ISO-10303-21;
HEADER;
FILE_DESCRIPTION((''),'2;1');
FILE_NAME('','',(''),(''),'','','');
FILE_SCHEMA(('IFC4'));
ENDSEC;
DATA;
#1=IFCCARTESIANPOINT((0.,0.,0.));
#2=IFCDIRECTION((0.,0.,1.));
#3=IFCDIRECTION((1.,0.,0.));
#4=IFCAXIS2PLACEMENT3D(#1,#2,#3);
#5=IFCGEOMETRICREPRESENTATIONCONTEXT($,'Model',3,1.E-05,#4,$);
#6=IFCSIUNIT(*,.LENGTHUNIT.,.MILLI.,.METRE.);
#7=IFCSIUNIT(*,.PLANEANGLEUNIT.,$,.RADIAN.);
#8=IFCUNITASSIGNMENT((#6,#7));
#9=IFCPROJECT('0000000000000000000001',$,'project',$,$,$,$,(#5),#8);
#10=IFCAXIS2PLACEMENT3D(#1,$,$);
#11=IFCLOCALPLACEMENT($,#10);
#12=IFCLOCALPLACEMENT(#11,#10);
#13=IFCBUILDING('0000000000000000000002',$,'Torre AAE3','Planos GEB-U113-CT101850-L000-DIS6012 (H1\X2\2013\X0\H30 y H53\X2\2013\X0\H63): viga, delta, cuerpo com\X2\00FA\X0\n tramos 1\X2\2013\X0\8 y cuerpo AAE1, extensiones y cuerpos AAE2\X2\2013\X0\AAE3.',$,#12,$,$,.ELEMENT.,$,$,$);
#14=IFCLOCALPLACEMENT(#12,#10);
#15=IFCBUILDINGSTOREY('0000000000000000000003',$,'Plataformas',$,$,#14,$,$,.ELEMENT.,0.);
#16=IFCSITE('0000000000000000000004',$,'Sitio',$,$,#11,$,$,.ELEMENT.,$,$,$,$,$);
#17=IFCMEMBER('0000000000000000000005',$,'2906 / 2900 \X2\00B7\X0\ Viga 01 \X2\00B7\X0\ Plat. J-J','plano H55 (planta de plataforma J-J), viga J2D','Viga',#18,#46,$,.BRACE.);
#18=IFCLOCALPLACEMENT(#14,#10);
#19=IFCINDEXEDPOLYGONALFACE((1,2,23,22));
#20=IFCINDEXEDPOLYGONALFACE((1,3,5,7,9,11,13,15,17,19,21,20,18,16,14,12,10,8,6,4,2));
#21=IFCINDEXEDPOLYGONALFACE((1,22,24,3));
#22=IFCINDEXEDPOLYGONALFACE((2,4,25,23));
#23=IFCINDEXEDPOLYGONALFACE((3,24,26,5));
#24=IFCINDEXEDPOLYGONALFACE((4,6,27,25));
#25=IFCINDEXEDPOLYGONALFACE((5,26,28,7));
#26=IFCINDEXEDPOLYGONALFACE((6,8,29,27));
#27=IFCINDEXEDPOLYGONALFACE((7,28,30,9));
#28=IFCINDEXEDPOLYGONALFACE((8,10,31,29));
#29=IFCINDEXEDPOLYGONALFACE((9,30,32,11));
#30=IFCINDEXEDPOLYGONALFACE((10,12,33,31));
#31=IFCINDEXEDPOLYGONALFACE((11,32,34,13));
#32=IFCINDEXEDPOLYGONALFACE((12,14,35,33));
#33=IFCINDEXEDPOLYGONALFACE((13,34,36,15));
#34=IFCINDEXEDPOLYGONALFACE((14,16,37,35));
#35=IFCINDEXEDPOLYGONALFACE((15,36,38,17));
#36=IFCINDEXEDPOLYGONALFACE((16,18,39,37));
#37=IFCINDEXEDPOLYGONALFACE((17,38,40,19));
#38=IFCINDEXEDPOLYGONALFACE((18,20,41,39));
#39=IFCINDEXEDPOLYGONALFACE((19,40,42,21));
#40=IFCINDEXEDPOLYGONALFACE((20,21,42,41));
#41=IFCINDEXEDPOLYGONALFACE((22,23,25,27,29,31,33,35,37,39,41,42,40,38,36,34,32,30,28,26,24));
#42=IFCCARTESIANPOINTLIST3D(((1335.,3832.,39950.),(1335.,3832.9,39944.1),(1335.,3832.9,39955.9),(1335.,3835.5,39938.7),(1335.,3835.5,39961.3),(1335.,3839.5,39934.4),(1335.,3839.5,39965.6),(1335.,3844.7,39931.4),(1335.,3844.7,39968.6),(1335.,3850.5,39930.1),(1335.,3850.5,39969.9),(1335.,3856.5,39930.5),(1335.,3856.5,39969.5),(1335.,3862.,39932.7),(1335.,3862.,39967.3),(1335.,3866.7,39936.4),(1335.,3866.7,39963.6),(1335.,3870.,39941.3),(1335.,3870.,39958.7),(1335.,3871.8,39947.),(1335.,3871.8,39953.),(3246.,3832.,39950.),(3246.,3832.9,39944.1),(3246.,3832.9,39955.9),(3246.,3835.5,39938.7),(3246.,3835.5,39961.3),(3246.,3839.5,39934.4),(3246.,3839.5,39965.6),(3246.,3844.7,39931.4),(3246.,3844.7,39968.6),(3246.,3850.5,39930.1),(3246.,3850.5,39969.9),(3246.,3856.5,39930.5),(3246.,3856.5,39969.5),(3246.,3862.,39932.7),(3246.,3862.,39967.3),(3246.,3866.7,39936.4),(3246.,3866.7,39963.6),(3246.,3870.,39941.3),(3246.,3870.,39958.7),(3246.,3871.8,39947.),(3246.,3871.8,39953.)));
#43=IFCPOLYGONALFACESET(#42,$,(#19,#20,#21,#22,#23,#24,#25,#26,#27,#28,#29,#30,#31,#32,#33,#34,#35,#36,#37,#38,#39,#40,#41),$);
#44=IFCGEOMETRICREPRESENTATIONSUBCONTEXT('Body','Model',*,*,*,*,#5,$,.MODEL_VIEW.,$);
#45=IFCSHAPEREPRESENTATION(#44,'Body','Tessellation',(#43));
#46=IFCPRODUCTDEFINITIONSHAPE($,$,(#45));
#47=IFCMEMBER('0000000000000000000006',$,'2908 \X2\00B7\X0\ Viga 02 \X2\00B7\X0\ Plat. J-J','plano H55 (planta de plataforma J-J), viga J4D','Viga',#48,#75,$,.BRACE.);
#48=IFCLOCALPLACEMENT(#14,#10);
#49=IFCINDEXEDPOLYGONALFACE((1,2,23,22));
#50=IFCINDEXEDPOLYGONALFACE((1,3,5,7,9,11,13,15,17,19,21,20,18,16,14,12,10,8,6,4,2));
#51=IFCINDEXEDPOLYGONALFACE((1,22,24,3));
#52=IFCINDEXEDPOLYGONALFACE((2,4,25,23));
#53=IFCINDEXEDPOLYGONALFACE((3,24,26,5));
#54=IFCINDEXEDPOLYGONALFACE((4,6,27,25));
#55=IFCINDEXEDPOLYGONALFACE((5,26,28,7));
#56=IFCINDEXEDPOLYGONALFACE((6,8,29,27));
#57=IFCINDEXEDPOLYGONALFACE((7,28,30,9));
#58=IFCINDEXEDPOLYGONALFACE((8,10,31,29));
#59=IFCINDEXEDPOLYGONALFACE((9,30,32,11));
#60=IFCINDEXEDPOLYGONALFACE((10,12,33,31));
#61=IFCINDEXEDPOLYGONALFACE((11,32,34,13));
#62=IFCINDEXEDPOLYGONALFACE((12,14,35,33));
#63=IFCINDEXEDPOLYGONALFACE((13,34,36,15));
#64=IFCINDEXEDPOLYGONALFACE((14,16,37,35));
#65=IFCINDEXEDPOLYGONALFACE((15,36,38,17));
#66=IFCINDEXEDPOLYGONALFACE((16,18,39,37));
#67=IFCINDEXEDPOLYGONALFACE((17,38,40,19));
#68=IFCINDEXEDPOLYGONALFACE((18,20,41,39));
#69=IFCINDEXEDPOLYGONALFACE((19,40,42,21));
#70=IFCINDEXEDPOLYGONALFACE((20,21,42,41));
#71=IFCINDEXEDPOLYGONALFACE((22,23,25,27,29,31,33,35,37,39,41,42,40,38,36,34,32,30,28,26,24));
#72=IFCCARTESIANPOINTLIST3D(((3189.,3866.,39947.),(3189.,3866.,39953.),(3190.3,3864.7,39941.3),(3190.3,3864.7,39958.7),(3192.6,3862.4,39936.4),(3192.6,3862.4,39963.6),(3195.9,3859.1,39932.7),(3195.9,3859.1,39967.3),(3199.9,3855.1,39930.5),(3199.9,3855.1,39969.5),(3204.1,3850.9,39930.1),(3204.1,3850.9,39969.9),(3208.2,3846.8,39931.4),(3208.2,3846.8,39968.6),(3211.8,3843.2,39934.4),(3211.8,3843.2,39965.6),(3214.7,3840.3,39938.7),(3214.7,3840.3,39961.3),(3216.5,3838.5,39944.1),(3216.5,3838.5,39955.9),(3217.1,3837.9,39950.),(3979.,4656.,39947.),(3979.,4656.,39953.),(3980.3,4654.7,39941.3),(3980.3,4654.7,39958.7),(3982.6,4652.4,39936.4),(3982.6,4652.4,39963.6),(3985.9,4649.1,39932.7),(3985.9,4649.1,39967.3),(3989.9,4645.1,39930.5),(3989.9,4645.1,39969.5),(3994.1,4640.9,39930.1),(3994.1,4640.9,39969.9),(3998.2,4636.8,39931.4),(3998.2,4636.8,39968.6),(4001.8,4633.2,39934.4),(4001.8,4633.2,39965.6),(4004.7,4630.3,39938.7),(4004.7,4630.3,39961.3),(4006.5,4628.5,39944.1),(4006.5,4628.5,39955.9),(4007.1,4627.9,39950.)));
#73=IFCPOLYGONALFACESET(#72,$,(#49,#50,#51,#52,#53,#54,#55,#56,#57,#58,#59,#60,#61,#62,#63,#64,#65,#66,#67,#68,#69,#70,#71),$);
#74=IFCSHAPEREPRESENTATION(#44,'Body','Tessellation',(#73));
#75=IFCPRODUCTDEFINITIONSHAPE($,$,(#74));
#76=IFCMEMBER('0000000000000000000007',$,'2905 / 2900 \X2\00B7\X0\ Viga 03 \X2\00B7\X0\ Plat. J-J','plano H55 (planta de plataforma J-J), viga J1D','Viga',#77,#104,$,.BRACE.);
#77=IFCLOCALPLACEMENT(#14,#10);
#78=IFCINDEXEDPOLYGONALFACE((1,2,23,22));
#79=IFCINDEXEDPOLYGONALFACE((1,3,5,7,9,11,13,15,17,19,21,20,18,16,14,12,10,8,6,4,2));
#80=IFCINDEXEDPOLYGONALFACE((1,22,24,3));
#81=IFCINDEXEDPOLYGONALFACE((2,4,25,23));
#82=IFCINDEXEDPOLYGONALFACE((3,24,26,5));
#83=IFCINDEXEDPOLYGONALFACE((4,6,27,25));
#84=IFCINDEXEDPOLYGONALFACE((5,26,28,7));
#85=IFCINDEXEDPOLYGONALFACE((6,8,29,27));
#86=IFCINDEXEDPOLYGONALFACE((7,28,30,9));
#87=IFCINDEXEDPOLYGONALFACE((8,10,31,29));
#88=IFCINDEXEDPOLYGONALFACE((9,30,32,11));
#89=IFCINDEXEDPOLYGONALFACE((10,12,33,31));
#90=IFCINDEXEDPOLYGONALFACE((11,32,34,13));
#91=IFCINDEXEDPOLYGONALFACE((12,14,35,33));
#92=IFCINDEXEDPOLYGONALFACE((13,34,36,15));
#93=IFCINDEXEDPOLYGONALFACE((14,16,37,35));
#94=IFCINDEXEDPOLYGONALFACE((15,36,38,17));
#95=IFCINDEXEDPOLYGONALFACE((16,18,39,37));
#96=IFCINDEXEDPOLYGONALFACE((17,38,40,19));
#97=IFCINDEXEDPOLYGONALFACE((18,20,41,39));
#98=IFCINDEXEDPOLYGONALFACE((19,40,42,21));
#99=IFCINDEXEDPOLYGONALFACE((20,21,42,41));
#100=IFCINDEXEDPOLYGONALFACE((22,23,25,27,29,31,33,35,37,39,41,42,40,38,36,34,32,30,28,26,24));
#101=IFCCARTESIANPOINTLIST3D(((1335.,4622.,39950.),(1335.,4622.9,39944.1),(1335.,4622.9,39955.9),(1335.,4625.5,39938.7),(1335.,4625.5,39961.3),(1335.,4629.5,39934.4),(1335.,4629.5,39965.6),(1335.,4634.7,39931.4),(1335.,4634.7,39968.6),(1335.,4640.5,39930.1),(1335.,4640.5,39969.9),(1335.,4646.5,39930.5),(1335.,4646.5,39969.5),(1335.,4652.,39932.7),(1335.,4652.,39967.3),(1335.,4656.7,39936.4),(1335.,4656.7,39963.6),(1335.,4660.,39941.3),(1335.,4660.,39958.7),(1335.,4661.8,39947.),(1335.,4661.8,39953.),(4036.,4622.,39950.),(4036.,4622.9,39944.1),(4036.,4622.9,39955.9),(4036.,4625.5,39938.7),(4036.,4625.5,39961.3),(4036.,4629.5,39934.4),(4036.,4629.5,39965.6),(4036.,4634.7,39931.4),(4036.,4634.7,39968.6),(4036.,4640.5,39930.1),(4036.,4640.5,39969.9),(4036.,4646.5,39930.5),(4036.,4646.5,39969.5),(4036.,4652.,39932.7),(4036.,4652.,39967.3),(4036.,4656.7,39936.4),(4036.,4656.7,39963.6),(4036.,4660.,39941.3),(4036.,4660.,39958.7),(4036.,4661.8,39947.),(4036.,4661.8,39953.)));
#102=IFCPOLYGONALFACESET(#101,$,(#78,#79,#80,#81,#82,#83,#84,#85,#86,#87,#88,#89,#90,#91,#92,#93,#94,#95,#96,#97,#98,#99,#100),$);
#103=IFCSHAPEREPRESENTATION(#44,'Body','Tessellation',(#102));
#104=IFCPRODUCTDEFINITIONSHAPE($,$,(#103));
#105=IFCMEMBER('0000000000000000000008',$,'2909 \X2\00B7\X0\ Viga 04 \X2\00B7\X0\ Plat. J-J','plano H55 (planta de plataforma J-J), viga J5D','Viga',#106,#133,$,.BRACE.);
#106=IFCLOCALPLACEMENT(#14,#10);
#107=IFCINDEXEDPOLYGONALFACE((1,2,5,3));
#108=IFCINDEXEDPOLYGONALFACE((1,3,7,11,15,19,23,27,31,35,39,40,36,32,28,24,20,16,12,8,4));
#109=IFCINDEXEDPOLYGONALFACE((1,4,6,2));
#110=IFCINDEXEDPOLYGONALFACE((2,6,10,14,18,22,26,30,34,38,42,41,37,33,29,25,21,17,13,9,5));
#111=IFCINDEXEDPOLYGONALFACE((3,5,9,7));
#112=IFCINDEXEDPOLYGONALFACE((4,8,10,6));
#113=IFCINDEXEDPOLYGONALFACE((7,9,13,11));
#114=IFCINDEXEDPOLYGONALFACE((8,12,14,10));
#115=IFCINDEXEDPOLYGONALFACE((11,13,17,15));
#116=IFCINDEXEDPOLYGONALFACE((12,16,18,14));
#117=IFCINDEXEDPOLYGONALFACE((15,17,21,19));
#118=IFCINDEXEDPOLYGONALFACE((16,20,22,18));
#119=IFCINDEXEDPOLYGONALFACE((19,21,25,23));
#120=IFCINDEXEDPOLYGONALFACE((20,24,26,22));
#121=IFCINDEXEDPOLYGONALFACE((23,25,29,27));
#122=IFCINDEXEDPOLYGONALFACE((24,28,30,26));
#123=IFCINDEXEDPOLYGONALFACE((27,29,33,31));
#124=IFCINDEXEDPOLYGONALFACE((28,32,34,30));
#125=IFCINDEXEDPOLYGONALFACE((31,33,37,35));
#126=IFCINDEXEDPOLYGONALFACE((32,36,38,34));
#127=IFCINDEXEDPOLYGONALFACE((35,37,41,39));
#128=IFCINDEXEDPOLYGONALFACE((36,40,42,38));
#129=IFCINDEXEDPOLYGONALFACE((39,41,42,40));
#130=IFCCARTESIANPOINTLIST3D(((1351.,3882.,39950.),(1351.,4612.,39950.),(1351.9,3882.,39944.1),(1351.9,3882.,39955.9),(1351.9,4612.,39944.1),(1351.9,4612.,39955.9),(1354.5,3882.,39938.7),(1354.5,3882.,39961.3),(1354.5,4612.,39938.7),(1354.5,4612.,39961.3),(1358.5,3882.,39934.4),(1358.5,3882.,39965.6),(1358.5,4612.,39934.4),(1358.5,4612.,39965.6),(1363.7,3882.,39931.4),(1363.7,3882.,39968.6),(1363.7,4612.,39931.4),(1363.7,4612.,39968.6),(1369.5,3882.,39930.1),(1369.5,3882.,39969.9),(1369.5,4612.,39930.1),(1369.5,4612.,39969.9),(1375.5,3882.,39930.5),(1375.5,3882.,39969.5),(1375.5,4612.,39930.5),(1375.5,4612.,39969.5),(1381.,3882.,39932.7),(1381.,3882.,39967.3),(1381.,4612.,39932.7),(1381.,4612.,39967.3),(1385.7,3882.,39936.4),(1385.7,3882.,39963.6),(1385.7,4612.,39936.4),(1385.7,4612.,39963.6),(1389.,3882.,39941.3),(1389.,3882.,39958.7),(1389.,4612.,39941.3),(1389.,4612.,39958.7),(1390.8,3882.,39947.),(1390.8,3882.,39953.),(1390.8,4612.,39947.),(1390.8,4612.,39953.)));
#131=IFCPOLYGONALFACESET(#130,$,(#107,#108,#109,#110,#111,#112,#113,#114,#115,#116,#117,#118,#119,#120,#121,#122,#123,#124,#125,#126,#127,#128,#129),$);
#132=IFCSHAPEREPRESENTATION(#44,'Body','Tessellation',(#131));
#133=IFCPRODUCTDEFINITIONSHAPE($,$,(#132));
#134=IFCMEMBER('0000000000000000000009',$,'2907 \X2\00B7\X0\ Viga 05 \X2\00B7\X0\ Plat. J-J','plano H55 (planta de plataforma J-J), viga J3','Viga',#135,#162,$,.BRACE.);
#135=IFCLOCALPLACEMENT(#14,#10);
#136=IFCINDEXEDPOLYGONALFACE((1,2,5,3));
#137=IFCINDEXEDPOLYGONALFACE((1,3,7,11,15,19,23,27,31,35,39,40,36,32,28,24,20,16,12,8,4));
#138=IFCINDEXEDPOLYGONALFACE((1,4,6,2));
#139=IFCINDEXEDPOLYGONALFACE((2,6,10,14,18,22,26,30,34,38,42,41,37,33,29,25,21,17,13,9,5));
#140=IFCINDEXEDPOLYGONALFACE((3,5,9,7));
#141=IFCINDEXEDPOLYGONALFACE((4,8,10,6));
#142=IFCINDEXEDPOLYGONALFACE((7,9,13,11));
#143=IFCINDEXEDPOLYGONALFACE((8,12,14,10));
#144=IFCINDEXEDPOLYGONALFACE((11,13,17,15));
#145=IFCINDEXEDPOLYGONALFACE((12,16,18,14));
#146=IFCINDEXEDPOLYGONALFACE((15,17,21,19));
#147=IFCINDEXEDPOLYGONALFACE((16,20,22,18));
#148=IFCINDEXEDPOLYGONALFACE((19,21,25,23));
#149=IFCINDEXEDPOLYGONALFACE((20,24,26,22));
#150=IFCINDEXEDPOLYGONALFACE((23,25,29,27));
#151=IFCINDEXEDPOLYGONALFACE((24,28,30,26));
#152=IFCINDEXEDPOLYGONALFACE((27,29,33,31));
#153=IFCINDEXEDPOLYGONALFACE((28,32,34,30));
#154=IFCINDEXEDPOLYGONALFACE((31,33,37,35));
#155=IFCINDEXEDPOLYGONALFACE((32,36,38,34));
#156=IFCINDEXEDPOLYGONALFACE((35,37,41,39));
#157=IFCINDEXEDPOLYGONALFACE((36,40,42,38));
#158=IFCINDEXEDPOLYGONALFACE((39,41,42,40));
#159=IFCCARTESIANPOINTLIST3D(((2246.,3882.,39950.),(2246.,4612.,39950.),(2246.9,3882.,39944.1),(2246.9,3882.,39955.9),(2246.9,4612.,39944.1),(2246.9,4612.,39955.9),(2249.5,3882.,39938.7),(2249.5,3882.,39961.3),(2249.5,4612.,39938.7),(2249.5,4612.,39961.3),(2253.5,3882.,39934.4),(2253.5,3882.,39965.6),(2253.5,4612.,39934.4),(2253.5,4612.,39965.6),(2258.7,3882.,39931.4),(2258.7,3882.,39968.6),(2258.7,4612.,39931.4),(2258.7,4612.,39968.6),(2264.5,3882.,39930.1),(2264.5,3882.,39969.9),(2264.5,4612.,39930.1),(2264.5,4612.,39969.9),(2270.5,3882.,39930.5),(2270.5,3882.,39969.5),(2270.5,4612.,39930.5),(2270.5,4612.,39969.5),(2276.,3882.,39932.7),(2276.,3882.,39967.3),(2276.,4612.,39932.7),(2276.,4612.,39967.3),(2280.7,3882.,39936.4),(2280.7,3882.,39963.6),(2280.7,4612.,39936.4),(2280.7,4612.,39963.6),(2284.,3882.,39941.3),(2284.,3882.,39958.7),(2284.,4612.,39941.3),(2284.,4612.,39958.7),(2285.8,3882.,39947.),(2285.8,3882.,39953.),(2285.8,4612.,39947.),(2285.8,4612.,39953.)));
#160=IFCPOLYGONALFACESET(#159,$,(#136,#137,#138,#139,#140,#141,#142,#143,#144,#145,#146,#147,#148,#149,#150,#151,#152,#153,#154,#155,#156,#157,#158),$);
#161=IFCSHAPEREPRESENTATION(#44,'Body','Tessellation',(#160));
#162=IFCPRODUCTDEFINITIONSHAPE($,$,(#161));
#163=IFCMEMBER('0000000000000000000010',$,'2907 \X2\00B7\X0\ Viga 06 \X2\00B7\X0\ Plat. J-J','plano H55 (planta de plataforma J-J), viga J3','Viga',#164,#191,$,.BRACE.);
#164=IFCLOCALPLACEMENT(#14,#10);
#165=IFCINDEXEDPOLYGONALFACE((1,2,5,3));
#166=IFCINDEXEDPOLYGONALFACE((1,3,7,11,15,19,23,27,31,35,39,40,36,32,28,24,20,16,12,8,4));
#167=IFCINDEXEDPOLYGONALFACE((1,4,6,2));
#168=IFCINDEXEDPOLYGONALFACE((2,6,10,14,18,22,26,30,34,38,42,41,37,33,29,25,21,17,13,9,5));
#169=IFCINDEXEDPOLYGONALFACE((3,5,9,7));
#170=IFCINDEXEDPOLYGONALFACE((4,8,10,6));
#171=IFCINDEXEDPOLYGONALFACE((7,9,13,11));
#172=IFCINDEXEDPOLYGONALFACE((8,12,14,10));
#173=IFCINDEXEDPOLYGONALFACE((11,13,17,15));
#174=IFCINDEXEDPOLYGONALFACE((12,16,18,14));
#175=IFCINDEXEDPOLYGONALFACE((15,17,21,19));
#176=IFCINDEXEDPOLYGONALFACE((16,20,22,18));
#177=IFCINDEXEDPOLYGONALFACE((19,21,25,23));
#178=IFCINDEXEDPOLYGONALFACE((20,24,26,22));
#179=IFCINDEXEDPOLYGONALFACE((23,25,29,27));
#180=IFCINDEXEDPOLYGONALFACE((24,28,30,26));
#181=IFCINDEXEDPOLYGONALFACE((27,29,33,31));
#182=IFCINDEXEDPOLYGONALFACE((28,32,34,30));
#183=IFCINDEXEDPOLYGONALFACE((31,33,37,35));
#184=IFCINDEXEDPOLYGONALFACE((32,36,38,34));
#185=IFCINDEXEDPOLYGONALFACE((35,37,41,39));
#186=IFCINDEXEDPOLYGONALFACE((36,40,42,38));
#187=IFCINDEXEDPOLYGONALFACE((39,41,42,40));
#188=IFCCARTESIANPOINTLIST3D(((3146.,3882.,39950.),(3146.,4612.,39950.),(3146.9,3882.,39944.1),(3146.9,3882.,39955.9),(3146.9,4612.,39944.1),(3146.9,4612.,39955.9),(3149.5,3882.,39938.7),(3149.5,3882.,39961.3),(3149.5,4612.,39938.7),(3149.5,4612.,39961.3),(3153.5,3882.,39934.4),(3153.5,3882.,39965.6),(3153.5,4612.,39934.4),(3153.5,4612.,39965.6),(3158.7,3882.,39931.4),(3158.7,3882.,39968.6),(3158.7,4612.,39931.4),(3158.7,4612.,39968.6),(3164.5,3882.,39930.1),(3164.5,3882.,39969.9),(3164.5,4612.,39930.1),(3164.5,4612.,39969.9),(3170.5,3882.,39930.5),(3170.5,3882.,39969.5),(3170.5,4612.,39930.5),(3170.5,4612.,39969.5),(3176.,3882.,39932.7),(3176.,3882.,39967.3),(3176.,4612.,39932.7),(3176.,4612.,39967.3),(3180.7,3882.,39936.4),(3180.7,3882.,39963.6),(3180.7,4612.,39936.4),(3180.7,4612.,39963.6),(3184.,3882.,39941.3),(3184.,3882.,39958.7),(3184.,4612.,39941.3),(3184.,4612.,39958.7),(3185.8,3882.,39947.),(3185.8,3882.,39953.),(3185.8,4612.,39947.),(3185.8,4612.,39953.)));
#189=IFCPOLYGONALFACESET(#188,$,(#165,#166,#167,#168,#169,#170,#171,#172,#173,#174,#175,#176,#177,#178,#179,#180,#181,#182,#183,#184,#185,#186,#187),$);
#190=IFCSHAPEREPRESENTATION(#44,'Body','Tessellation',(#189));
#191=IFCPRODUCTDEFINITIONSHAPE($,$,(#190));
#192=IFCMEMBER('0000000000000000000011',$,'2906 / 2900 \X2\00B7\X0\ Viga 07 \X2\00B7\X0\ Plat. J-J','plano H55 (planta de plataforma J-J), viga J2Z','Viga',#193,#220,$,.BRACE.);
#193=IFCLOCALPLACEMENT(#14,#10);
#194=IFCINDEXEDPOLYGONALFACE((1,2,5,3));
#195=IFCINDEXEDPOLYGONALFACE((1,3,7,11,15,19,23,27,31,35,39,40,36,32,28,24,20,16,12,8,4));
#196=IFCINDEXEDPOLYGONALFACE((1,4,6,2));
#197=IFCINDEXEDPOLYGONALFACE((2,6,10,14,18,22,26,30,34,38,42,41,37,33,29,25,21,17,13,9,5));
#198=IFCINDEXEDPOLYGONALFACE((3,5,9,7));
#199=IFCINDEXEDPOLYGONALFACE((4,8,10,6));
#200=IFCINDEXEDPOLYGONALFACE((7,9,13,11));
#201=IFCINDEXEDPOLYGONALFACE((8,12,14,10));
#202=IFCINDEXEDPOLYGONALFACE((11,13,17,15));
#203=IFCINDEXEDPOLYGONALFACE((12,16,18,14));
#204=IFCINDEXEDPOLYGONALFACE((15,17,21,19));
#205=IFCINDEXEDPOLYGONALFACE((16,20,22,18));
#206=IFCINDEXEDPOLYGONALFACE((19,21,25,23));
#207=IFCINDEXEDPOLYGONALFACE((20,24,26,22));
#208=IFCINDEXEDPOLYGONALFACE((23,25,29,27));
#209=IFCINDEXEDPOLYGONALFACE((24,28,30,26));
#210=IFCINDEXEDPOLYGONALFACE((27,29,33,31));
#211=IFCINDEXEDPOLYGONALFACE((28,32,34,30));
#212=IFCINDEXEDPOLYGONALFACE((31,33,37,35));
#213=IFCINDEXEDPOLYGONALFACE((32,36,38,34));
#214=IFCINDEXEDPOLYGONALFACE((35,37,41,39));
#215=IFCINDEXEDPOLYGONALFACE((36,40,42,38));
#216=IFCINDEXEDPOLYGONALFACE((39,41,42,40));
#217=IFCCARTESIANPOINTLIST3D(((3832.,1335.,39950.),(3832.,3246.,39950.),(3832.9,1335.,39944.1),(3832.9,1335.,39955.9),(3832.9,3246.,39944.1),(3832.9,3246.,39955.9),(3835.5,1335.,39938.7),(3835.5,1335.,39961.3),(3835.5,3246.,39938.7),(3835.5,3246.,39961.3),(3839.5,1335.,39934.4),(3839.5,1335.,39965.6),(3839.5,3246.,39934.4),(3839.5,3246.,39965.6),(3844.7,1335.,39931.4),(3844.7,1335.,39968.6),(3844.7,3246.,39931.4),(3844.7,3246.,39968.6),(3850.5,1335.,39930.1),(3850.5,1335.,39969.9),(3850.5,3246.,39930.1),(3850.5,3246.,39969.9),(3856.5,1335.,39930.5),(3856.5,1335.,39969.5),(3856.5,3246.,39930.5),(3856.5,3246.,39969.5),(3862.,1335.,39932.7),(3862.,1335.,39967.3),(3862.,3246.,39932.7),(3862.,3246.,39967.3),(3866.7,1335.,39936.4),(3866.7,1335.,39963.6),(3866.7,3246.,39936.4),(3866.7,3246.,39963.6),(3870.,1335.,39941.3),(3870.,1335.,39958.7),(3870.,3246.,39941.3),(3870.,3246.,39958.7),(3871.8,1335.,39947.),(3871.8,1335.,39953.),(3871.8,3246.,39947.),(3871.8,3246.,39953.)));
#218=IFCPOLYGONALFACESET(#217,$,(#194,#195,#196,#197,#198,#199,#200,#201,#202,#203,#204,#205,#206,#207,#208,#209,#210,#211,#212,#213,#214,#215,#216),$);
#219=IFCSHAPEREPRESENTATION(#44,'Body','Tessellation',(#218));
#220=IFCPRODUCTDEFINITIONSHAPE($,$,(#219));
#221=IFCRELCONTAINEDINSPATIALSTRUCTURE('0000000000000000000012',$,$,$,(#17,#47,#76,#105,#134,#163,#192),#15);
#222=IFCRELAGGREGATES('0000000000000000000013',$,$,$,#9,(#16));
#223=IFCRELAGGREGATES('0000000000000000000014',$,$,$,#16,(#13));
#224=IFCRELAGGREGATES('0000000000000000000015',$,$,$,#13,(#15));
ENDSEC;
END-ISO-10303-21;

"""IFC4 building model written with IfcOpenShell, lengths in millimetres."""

from ifc_helpers import new_model, si_unit, frame, origin, origin_with_axes, place, context, subcontext, project, spatial, circle, extrude, element, save


model = new_model("IFC4")

# Units and contexts
model_context = context("Model", 3, precision=1e-05, world=origin_with_axes())
body_context = subcontext(model_context, "Body", "Model", "MODEL_VIEW")
ifc_project = project(units=[si_unit("LENGTHUNIT", "METRE", prefix="MILLI"), si_unit("PLANEANGLEUNIT", "RADIAN")], contexts=[model_context])

# Site, building, storey
site_placement = place(None, origin())
site = spatial("IfcSite", under=ifc_project, at=site_placement, Name="Sitio", CompositionType="ELEMENT")
building_placement = place(site_placement, origin())
building = spatial("IfcBuilding", under=site, at=building_placement, Name="Torre AAE3", Description="Planos GEB-U113-CT101850-L000-DIS6012 (H1–H30 y H53–H63): viga, delta, cuerpo común tramos 1–8 y cuerpo AAE1, extensiones y cuerpos AAE2–AAE3.", CompositionType="ELEMENT")
storey_placement = place(building_placement, origin())
storey = spatial("IfcBuildingStorey", under=building, at=storey_placement, Name="Plataformas", CompositionType="ELEMENT", Elevation=0.0)

# Members
member_1_placement = place(storey_placement, frame((1335.0, 3852.0, 39950.0), z_axis=(1.0, 0.0, 0.0), x_axis=(0.0, -1.0, 0.0)))
element("IfcMember", 1, at=member_1_placement, inside=storey, Name="2906 / 2900 · Viga 01 · Plat. J-J", Description="plano H55 (planta de plataforma J-J), viga J2D", ObjectType="Viga", PredefinedType="BRACE", context=body_context, shape_type="SweptSolid", body=[
    extrude(circle(Radius=20.0), None, (0.0, 0.0, 1.0), 1911.0),
])
member_2_placement = place(storey_placement, frame((3993.0, 4642.0, 39950.0), z_axis=(-0.707107, -0.707107, 0.0), x_axis=(0.707107, -0.707107, 0.0)))
element("IfcMember", 2, at=member_2_placement, inside=storey, Name="2908 · Viga 02 · Plat. J-J", Description="plano H55 (planta de plataforma J-J), viga J4D", ObjectType="Viga", PredefinedType="BRACE", context=body_context, shape_type="SweptSolid", body=[
    extrude(circle(Radius=20.0), None, (0.0, 0.0, 1.0), 1117.2),
])
member_3_placement = place(storey_placement, frame((4036.0, 4642.0, 39950.0), z_axis=(-1.0, 0.0, 0.0), x_axis=(0.0, -1.0, 0.0)))
element("IfcMember", 3, at=member_3_placement, inside=storey, Name="2905 / 2900 · Viga 03 · Plat. J-J", Description="plano H55 (planta de plataforma J-J), viga J1D", ObjectType="Viga", PredefinedType="BRACE", context=body_context, shape_type="SweptSolid", body=[
    extrude(circle(Radius=20.0), None, (0.0, 0.0, 1.0), 2701.0),
])
for number, where, z_axis, x_axis, name, description in (
    (4, (1371.0, 4612.0, 39950.0), (0.0, -1.0, 0.0), (-1.0, 0.0, 0.0), "2909 · Viga 04 · Plat. J-J", "plano H55 (planta de plataforma J-J), viga J5D"),
    (5, (2266.0, 4612.0, 39950.0), (0.0, -1.0, 0.0), (-1.0, 0.0, 0.0), "2907 · Viga 05 · Plat. J-J", "plano H55 (planta de plataforma J-J), viga J3"),
    (6, (3166.0, 4612.0, 39950.0), (0.0, -1.0, 0.0), (-1.0, 0.0, 0.0), "2907 · Viga 06 · Plat. J-J", "plano H55 (planta de plataforma J-J), viga J3"),
):
    element("IfcMember", number, at=place(storey_placement, frame(where, z_axis=z_axis, x_axis=x_axis)), inside=storey, Name=name, Description=description, ObjectType="Viga", PredefinedType="BRACE", context=body_context, shape_type="SweptSolid", body=[
        extrude(circle(Radius=20.0), None, (0.0, 0.0, 1.0), 730.0),
    ])
member_4_placement = place(storey_placement, frame((3852.0, 1335.0, 39950.0), z_axis=(0.0, 1.0, 0.0), x_axis=(-1.0, 0.0, 0.0)))
element("IfcMember", 7, at=member_4_placement, inside=storey, Name="2906 / 2900 · Viga 07 · Plat. J-J", Description="plano H55 (planta de plataforma J-J), viga J2Z", ObjectType="Viga", PredefinedType="BRACE", context=body_context, shape_type="SweptSolid", body=[
    extrude(circle(Radius=20.0), None, (0.0, 0.0, 1.0), 1911.0),
])

save(model, "model.ifc")
